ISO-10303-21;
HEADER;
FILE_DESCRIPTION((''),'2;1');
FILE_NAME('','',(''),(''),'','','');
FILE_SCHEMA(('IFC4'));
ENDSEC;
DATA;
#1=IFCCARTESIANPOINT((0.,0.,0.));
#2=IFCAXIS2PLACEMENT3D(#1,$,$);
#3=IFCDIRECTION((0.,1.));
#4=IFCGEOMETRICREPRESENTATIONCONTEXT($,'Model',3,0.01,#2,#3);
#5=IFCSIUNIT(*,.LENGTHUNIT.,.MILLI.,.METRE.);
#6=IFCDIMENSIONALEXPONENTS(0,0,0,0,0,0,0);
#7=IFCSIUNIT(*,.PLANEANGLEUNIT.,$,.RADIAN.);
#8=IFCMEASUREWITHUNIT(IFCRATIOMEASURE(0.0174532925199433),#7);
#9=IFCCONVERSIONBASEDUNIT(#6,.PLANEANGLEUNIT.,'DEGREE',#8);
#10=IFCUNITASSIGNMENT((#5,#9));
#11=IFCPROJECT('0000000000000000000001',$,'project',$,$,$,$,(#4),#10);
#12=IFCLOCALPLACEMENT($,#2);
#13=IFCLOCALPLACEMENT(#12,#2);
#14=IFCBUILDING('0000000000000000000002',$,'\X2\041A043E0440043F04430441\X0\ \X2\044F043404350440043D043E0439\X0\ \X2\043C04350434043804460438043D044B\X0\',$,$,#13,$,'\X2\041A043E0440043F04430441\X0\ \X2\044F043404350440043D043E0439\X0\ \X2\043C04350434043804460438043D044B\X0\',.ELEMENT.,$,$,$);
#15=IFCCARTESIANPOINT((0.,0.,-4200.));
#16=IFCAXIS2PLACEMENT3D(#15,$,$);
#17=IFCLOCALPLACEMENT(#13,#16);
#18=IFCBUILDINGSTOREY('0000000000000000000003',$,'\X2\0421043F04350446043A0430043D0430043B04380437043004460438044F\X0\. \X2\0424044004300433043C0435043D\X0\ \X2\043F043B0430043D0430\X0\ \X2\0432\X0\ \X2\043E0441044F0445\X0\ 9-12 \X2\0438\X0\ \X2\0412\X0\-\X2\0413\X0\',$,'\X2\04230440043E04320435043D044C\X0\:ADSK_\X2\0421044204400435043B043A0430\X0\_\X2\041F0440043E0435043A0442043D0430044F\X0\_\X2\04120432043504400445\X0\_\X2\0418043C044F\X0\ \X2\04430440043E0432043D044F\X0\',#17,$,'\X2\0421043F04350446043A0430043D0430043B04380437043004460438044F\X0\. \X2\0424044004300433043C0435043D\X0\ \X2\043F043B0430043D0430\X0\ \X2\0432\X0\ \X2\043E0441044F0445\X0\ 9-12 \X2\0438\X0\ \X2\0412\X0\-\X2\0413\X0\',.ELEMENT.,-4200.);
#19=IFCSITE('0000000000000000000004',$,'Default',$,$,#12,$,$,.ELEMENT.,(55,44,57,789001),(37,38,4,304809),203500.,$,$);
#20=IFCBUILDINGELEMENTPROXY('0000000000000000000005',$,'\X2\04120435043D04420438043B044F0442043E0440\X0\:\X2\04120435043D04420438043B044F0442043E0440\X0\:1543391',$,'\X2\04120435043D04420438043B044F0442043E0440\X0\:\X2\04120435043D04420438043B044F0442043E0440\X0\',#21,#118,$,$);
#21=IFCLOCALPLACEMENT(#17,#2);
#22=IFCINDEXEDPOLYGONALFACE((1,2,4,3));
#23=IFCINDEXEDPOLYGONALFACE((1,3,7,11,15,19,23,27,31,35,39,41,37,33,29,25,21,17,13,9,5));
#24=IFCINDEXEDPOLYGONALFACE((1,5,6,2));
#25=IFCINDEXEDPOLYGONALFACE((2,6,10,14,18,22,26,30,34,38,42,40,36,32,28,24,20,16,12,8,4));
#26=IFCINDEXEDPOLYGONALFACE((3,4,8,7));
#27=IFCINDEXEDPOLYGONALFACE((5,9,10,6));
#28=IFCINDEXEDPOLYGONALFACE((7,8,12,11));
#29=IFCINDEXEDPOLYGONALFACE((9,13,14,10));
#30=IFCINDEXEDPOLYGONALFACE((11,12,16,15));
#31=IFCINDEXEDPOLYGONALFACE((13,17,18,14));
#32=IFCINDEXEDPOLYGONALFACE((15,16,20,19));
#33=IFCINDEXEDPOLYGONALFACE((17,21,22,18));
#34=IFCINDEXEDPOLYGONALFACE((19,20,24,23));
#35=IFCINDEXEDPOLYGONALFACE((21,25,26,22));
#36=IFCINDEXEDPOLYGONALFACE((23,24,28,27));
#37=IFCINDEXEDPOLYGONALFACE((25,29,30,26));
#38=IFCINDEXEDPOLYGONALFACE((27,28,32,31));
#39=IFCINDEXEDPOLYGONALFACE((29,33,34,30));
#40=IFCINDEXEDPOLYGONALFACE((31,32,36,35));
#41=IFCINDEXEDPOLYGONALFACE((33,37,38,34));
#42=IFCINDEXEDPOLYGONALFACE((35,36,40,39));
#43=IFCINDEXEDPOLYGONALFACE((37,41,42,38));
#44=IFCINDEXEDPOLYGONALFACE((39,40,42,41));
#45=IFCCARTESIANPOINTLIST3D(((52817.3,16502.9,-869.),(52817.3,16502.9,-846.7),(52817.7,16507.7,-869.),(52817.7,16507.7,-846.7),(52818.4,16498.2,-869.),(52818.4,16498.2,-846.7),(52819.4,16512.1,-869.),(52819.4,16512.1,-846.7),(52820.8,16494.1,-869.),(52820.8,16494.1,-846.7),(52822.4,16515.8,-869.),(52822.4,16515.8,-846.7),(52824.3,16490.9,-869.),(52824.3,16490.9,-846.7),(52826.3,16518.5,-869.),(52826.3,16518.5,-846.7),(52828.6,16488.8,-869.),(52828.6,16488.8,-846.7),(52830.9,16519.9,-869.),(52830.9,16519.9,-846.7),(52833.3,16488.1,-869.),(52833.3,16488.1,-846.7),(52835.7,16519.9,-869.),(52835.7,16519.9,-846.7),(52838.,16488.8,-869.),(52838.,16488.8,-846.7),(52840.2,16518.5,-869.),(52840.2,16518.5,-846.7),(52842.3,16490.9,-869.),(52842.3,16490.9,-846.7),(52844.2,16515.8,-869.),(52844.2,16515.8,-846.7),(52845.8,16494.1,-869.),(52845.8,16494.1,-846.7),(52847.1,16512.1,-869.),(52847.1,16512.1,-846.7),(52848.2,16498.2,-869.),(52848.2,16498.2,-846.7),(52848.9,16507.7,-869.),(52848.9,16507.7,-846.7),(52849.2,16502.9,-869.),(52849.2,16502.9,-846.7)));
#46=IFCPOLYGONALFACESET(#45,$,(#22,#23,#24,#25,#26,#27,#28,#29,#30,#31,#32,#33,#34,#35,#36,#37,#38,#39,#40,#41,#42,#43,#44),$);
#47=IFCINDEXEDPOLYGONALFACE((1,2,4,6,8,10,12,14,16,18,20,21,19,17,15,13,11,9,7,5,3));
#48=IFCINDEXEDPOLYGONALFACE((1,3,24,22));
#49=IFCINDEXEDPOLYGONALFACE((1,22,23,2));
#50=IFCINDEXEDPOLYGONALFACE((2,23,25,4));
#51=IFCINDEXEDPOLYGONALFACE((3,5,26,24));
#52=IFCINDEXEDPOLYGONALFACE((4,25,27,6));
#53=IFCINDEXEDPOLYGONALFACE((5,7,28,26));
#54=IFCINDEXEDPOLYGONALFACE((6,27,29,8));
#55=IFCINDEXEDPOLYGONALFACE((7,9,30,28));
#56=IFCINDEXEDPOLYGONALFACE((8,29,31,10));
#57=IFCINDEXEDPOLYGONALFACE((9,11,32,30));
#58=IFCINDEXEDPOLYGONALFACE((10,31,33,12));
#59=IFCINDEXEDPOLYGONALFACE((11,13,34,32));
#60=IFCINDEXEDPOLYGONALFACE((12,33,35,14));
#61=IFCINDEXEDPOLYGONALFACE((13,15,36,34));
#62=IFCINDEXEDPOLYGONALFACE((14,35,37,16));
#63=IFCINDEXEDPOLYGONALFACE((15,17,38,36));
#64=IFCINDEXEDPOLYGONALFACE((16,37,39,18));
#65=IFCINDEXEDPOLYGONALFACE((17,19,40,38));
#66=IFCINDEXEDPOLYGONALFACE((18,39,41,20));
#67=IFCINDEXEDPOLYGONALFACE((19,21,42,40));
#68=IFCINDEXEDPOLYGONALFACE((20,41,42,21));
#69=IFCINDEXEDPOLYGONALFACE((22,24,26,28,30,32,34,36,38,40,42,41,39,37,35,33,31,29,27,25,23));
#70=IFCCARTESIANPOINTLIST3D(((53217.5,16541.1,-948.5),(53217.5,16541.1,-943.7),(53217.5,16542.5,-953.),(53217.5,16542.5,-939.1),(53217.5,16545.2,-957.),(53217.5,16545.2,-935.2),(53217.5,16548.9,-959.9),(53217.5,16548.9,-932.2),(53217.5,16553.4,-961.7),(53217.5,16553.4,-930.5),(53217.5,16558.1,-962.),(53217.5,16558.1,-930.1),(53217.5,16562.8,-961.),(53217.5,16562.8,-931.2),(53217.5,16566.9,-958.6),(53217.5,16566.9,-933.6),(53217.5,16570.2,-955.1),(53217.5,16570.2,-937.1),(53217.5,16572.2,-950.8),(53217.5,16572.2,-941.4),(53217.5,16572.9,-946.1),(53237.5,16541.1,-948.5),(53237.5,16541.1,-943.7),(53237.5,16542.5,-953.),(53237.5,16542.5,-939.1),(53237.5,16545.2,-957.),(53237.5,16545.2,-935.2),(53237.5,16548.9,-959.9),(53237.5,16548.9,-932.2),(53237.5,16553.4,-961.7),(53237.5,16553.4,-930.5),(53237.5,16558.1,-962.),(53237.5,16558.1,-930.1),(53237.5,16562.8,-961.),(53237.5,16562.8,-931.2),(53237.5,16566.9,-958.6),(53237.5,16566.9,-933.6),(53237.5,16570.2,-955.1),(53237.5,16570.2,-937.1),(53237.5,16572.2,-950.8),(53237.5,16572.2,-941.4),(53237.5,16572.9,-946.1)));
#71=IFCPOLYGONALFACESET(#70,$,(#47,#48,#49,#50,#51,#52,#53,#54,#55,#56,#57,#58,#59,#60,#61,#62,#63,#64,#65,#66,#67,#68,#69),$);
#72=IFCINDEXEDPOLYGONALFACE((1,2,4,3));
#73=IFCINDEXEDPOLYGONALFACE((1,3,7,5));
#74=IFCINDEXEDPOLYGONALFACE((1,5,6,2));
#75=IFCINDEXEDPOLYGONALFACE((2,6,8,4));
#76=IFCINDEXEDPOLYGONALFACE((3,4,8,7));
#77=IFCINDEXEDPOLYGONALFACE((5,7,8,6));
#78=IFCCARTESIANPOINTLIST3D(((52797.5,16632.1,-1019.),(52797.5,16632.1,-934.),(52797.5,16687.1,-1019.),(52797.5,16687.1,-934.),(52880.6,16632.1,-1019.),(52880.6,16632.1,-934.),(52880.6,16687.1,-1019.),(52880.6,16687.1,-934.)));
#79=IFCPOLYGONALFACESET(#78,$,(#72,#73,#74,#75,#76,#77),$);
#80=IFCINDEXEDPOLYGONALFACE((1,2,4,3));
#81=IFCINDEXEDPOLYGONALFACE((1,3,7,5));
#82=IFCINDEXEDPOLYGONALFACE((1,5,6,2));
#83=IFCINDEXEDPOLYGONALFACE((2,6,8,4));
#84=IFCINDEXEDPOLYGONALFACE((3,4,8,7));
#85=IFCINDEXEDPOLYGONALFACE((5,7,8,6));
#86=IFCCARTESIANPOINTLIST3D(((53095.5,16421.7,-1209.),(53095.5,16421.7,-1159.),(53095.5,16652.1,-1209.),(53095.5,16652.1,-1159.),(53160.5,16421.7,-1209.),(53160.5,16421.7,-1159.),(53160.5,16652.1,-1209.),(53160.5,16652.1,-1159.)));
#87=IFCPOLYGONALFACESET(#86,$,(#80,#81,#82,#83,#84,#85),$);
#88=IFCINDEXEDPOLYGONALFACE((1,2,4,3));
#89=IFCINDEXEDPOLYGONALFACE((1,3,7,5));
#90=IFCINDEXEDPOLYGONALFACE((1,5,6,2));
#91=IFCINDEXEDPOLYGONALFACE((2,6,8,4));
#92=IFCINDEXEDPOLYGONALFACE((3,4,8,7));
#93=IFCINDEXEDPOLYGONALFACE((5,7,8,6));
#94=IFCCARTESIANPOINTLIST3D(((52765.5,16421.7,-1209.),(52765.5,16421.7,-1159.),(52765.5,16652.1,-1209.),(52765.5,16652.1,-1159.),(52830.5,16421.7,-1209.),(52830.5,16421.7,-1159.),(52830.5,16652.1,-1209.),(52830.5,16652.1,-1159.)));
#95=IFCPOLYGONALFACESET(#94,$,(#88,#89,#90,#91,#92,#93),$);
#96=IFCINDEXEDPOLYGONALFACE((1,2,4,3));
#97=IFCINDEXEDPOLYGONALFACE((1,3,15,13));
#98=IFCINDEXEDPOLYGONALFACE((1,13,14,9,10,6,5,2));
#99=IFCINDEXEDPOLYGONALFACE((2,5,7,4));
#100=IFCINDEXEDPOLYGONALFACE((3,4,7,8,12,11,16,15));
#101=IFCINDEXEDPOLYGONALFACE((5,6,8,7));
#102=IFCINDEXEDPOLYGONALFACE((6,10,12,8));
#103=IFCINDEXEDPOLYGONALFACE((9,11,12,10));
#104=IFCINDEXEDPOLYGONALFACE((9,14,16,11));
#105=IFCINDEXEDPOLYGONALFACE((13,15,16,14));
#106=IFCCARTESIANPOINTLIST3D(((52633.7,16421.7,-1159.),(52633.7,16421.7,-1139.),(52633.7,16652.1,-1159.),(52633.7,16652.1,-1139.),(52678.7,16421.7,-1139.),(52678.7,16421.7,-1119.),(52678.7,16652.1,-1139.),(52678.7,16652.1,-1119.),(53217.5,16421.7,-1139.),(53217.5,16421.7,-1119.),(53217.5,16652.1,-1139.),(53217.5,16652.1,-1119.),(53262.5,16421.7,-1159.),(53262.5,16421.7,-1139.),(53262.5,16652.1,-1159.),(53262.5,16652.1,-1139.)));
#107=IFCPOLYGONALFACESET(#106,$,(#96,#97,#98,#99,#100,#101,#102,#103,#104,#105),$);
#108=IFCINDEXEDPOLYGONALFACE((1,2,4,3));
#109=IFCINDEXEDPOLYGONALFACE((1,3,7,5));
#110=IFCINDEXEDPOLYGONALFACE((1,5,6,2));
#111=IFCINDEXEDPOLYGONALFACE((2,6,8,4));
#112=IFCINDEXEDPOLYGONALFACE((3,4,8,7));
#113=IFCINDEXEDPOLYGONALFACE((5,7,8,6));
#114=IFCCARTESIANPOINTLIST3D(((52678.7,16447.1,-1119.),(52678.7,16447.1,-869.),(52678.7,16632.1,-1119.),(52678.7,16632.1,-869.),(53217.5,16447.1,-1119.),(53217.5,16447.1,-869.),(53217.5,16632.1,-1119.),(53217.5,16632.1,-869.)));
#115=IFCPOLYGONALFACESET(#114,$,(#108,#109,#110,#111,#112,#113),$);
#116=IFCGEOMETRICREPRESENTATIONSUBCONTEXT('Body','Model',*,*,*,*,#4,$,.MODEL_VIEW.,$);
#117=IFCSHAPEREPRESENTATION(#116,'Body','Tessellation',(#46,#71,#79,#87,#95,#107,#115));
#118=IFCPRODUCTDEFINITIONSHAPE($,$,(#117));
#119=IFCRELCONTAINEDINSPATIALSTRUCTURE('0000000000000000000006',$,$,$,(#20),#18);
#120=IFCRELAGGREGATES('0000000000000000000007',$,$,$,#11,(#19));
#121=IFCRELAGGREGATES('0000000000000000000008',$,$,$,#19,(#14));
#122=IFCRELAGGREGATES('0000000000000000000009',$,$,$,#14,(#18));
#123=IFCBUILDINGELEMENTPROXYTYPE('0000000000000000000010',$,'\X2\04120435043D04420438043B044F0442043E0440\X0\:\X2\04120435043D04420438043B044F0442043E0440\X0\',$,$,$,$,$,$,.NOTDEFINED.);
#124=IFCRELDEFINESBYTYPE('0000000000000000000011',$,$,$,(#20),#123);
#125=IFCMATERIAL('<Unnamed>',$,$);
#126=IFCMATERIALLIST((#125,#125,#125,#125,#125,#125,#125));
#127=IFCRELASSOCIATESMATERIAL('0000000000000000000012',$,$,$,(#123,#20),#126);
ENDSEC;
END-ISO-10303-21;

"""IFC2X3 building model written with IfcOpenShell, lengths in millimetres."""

from ifc_helpers import new_model, entity, si_unit, converted_unit, direction, frame, origin, origin_2d_with_axis, place, context, subcontext, project, spatial, polyline, rectangle, circle, outline, extrude, source, transform, mapped, material, material_list, type_object, type_shapes, element, save


model = new_model("IFC2X3")

# Units and contexts
model_context = context("Model", 3, precision=0.01, world=origin(), true_north=direction((0.0, 1.0)))
body_context = subcontext(model_context, "Body", "Model", "MODEL_VIEW")
ifc_project = project(units=[si_unit("LENGTHUNIT", "METRE", prefix="MILLI"), converted_unit("PLANEANGLEUNIT", "DEGREE", entity("IfcRatioMeasure", 0.0174532925199433), si_unit("PLANEANGLEUNIT", "RADIAN"), dimensions=[0, 0, 0, 0, 0, 0, 0])], contexts=[model_context])

# Site, building, storey
site_placement = place(None, origin())
site = spatial("IfcSite", under=ifc_project, at=site_placement, Name="Default", CompositionType="ELEMENT", RefLatitude=(55, 44, 57, 789001), RefLongitude=(37, 38, 4, 304809), RefElevation=203500.0)
building_placement = place(site_placement, origin())
building = spatial("IfcBuilding", under=site, at=building_placement, Name="Корпус ядерной медицины", LongName="Корпус ядерной медицины", CompositionType="ELEMENT")
storey_placement = place(building_placement, frame((0.0, 0.0, -4200.0)))
storey = spatial("IfcBuildingStorey", under=building, at=storey_placement, Name="Спецканализация. Фрагмен плана в осях 9-12 и В-Г", ObjectType="Уровень:ADSK_Стрелка_Проектная_Вверх_Имя уровня", LongName="Спецканализация. Фрагмен плана в осях 9-12 и В-Г", CompositionType="ELEMENT", Elevation=-4200.0)

# Building element proxy
ifc_material_1 = material(Name="<Unnamed>")
ifc_material_list_1 = material_list([ifc_material_1, ifc_material_1, ifc_material_1, ifc_material_1, ifc_material_1, ifc_material_1, ifc_material_1])
building_element_proxy_type_1 = type_object("IfcBuildingElementProxyType", Name="Вентилятор:Вентилятор", PredefinedType="NOTDEFINED", material=ifc_material_list_1)
shared_shape_1 = source(origin(), body_context, "Body", "SweptSolid", [
    extrude(circle(Radius=16.0, at=origin_2d_with_axis()), frame((15.8, 107.7, 250.0)), (0.0, 0.0, 1.0), 22.4),
    extrude(circle(Radius=16.0, at=origin_2d_with_axis()), frame((-37.0, 492.0, 173.0), z_axis=(0.0, 1.0, 0.0), x_axis=(-1.0, 0.0, 0.0)), (0.0, 0.0, 1.0), 20.0),
    extrude(rectangle(XDim=83.1, YDim=55.0, at=origin_2d_with_axis()), frame((-139.7, 113.5, 100.0), z_axis=(0.0, 0.0, 1.0), x_axis=(0.0, 1.0, 0.0)), (0.0, 0.0, 1.0), 85.0),
    extrude(rectangle(XDim=230.4, YDim=65.0, at=origin_2d_with_axis()), frame((-16.9, 402.4, -90.0), z_axis=(0.0, 0.0, 1.0), x_axis=(-1.0, 0.0, 0.0)), (0.0, 0.0, 1.0), 50.0),
    extrude(rectangle(XDim=230.4, YDim=65.0, at=origin_2d_with_axis()), frame((-16.9, 72.4, -90.0), z_axis=(0.0, 0.0, 1.0), x_axis=(-1.0, 0.0, 0.0)), (0.0, 0.0, 1.0), 50.0),
    extrude(outline(polyline([(0.0, -269.4), (20.0, -269.4), (20.0, 269.4), (0.0, 269.4), (0.0, 314.4), (-20.0, 314.4), (-20.0, -314.4), (0.0, -314.4), (0.0, -269.4)])), frame((-132.2, 222.6, -20.0), z_axis=(1.0, 0.0, 0.0), x_axis=(0.0, 0.0, 1.0)), (0.0, 0.0, 1.0), 230.4),
    extrude(rectangle(XDim=185.0, YDim=538.8, at=origin_2d_with_axis()), frame((-19.7, 222.6, 0.0)), (0.0, 0.0, 1.0), 250.0),
])
type_shapes(building_element_proxy_type_1, [shared_shape_1])
proxy_1_placement = place(storey_placement, frame((52725.5, 16519.9, -1119.0), z_axis=(0.0, 0.0, 1.0), x_axis=(0.0, -1.0, 0.0)))
element("IfcBuildingElementProxy", 1, at=proxy_1_placement, inside=storey, type_object=building_element_proxy_type_1, material=ifc_material_list_1, Name="Вентилятор:Вентилятор:1543391", ObjectType="Вентилятор:Вентилятор", context=body_context, shape_type="MappedRepresentation", body=[
    mapped(shared_shape_1, transform((0.0, 0.0, 0.0), scale=1.0)),
])

save(model, "model.ifc")
